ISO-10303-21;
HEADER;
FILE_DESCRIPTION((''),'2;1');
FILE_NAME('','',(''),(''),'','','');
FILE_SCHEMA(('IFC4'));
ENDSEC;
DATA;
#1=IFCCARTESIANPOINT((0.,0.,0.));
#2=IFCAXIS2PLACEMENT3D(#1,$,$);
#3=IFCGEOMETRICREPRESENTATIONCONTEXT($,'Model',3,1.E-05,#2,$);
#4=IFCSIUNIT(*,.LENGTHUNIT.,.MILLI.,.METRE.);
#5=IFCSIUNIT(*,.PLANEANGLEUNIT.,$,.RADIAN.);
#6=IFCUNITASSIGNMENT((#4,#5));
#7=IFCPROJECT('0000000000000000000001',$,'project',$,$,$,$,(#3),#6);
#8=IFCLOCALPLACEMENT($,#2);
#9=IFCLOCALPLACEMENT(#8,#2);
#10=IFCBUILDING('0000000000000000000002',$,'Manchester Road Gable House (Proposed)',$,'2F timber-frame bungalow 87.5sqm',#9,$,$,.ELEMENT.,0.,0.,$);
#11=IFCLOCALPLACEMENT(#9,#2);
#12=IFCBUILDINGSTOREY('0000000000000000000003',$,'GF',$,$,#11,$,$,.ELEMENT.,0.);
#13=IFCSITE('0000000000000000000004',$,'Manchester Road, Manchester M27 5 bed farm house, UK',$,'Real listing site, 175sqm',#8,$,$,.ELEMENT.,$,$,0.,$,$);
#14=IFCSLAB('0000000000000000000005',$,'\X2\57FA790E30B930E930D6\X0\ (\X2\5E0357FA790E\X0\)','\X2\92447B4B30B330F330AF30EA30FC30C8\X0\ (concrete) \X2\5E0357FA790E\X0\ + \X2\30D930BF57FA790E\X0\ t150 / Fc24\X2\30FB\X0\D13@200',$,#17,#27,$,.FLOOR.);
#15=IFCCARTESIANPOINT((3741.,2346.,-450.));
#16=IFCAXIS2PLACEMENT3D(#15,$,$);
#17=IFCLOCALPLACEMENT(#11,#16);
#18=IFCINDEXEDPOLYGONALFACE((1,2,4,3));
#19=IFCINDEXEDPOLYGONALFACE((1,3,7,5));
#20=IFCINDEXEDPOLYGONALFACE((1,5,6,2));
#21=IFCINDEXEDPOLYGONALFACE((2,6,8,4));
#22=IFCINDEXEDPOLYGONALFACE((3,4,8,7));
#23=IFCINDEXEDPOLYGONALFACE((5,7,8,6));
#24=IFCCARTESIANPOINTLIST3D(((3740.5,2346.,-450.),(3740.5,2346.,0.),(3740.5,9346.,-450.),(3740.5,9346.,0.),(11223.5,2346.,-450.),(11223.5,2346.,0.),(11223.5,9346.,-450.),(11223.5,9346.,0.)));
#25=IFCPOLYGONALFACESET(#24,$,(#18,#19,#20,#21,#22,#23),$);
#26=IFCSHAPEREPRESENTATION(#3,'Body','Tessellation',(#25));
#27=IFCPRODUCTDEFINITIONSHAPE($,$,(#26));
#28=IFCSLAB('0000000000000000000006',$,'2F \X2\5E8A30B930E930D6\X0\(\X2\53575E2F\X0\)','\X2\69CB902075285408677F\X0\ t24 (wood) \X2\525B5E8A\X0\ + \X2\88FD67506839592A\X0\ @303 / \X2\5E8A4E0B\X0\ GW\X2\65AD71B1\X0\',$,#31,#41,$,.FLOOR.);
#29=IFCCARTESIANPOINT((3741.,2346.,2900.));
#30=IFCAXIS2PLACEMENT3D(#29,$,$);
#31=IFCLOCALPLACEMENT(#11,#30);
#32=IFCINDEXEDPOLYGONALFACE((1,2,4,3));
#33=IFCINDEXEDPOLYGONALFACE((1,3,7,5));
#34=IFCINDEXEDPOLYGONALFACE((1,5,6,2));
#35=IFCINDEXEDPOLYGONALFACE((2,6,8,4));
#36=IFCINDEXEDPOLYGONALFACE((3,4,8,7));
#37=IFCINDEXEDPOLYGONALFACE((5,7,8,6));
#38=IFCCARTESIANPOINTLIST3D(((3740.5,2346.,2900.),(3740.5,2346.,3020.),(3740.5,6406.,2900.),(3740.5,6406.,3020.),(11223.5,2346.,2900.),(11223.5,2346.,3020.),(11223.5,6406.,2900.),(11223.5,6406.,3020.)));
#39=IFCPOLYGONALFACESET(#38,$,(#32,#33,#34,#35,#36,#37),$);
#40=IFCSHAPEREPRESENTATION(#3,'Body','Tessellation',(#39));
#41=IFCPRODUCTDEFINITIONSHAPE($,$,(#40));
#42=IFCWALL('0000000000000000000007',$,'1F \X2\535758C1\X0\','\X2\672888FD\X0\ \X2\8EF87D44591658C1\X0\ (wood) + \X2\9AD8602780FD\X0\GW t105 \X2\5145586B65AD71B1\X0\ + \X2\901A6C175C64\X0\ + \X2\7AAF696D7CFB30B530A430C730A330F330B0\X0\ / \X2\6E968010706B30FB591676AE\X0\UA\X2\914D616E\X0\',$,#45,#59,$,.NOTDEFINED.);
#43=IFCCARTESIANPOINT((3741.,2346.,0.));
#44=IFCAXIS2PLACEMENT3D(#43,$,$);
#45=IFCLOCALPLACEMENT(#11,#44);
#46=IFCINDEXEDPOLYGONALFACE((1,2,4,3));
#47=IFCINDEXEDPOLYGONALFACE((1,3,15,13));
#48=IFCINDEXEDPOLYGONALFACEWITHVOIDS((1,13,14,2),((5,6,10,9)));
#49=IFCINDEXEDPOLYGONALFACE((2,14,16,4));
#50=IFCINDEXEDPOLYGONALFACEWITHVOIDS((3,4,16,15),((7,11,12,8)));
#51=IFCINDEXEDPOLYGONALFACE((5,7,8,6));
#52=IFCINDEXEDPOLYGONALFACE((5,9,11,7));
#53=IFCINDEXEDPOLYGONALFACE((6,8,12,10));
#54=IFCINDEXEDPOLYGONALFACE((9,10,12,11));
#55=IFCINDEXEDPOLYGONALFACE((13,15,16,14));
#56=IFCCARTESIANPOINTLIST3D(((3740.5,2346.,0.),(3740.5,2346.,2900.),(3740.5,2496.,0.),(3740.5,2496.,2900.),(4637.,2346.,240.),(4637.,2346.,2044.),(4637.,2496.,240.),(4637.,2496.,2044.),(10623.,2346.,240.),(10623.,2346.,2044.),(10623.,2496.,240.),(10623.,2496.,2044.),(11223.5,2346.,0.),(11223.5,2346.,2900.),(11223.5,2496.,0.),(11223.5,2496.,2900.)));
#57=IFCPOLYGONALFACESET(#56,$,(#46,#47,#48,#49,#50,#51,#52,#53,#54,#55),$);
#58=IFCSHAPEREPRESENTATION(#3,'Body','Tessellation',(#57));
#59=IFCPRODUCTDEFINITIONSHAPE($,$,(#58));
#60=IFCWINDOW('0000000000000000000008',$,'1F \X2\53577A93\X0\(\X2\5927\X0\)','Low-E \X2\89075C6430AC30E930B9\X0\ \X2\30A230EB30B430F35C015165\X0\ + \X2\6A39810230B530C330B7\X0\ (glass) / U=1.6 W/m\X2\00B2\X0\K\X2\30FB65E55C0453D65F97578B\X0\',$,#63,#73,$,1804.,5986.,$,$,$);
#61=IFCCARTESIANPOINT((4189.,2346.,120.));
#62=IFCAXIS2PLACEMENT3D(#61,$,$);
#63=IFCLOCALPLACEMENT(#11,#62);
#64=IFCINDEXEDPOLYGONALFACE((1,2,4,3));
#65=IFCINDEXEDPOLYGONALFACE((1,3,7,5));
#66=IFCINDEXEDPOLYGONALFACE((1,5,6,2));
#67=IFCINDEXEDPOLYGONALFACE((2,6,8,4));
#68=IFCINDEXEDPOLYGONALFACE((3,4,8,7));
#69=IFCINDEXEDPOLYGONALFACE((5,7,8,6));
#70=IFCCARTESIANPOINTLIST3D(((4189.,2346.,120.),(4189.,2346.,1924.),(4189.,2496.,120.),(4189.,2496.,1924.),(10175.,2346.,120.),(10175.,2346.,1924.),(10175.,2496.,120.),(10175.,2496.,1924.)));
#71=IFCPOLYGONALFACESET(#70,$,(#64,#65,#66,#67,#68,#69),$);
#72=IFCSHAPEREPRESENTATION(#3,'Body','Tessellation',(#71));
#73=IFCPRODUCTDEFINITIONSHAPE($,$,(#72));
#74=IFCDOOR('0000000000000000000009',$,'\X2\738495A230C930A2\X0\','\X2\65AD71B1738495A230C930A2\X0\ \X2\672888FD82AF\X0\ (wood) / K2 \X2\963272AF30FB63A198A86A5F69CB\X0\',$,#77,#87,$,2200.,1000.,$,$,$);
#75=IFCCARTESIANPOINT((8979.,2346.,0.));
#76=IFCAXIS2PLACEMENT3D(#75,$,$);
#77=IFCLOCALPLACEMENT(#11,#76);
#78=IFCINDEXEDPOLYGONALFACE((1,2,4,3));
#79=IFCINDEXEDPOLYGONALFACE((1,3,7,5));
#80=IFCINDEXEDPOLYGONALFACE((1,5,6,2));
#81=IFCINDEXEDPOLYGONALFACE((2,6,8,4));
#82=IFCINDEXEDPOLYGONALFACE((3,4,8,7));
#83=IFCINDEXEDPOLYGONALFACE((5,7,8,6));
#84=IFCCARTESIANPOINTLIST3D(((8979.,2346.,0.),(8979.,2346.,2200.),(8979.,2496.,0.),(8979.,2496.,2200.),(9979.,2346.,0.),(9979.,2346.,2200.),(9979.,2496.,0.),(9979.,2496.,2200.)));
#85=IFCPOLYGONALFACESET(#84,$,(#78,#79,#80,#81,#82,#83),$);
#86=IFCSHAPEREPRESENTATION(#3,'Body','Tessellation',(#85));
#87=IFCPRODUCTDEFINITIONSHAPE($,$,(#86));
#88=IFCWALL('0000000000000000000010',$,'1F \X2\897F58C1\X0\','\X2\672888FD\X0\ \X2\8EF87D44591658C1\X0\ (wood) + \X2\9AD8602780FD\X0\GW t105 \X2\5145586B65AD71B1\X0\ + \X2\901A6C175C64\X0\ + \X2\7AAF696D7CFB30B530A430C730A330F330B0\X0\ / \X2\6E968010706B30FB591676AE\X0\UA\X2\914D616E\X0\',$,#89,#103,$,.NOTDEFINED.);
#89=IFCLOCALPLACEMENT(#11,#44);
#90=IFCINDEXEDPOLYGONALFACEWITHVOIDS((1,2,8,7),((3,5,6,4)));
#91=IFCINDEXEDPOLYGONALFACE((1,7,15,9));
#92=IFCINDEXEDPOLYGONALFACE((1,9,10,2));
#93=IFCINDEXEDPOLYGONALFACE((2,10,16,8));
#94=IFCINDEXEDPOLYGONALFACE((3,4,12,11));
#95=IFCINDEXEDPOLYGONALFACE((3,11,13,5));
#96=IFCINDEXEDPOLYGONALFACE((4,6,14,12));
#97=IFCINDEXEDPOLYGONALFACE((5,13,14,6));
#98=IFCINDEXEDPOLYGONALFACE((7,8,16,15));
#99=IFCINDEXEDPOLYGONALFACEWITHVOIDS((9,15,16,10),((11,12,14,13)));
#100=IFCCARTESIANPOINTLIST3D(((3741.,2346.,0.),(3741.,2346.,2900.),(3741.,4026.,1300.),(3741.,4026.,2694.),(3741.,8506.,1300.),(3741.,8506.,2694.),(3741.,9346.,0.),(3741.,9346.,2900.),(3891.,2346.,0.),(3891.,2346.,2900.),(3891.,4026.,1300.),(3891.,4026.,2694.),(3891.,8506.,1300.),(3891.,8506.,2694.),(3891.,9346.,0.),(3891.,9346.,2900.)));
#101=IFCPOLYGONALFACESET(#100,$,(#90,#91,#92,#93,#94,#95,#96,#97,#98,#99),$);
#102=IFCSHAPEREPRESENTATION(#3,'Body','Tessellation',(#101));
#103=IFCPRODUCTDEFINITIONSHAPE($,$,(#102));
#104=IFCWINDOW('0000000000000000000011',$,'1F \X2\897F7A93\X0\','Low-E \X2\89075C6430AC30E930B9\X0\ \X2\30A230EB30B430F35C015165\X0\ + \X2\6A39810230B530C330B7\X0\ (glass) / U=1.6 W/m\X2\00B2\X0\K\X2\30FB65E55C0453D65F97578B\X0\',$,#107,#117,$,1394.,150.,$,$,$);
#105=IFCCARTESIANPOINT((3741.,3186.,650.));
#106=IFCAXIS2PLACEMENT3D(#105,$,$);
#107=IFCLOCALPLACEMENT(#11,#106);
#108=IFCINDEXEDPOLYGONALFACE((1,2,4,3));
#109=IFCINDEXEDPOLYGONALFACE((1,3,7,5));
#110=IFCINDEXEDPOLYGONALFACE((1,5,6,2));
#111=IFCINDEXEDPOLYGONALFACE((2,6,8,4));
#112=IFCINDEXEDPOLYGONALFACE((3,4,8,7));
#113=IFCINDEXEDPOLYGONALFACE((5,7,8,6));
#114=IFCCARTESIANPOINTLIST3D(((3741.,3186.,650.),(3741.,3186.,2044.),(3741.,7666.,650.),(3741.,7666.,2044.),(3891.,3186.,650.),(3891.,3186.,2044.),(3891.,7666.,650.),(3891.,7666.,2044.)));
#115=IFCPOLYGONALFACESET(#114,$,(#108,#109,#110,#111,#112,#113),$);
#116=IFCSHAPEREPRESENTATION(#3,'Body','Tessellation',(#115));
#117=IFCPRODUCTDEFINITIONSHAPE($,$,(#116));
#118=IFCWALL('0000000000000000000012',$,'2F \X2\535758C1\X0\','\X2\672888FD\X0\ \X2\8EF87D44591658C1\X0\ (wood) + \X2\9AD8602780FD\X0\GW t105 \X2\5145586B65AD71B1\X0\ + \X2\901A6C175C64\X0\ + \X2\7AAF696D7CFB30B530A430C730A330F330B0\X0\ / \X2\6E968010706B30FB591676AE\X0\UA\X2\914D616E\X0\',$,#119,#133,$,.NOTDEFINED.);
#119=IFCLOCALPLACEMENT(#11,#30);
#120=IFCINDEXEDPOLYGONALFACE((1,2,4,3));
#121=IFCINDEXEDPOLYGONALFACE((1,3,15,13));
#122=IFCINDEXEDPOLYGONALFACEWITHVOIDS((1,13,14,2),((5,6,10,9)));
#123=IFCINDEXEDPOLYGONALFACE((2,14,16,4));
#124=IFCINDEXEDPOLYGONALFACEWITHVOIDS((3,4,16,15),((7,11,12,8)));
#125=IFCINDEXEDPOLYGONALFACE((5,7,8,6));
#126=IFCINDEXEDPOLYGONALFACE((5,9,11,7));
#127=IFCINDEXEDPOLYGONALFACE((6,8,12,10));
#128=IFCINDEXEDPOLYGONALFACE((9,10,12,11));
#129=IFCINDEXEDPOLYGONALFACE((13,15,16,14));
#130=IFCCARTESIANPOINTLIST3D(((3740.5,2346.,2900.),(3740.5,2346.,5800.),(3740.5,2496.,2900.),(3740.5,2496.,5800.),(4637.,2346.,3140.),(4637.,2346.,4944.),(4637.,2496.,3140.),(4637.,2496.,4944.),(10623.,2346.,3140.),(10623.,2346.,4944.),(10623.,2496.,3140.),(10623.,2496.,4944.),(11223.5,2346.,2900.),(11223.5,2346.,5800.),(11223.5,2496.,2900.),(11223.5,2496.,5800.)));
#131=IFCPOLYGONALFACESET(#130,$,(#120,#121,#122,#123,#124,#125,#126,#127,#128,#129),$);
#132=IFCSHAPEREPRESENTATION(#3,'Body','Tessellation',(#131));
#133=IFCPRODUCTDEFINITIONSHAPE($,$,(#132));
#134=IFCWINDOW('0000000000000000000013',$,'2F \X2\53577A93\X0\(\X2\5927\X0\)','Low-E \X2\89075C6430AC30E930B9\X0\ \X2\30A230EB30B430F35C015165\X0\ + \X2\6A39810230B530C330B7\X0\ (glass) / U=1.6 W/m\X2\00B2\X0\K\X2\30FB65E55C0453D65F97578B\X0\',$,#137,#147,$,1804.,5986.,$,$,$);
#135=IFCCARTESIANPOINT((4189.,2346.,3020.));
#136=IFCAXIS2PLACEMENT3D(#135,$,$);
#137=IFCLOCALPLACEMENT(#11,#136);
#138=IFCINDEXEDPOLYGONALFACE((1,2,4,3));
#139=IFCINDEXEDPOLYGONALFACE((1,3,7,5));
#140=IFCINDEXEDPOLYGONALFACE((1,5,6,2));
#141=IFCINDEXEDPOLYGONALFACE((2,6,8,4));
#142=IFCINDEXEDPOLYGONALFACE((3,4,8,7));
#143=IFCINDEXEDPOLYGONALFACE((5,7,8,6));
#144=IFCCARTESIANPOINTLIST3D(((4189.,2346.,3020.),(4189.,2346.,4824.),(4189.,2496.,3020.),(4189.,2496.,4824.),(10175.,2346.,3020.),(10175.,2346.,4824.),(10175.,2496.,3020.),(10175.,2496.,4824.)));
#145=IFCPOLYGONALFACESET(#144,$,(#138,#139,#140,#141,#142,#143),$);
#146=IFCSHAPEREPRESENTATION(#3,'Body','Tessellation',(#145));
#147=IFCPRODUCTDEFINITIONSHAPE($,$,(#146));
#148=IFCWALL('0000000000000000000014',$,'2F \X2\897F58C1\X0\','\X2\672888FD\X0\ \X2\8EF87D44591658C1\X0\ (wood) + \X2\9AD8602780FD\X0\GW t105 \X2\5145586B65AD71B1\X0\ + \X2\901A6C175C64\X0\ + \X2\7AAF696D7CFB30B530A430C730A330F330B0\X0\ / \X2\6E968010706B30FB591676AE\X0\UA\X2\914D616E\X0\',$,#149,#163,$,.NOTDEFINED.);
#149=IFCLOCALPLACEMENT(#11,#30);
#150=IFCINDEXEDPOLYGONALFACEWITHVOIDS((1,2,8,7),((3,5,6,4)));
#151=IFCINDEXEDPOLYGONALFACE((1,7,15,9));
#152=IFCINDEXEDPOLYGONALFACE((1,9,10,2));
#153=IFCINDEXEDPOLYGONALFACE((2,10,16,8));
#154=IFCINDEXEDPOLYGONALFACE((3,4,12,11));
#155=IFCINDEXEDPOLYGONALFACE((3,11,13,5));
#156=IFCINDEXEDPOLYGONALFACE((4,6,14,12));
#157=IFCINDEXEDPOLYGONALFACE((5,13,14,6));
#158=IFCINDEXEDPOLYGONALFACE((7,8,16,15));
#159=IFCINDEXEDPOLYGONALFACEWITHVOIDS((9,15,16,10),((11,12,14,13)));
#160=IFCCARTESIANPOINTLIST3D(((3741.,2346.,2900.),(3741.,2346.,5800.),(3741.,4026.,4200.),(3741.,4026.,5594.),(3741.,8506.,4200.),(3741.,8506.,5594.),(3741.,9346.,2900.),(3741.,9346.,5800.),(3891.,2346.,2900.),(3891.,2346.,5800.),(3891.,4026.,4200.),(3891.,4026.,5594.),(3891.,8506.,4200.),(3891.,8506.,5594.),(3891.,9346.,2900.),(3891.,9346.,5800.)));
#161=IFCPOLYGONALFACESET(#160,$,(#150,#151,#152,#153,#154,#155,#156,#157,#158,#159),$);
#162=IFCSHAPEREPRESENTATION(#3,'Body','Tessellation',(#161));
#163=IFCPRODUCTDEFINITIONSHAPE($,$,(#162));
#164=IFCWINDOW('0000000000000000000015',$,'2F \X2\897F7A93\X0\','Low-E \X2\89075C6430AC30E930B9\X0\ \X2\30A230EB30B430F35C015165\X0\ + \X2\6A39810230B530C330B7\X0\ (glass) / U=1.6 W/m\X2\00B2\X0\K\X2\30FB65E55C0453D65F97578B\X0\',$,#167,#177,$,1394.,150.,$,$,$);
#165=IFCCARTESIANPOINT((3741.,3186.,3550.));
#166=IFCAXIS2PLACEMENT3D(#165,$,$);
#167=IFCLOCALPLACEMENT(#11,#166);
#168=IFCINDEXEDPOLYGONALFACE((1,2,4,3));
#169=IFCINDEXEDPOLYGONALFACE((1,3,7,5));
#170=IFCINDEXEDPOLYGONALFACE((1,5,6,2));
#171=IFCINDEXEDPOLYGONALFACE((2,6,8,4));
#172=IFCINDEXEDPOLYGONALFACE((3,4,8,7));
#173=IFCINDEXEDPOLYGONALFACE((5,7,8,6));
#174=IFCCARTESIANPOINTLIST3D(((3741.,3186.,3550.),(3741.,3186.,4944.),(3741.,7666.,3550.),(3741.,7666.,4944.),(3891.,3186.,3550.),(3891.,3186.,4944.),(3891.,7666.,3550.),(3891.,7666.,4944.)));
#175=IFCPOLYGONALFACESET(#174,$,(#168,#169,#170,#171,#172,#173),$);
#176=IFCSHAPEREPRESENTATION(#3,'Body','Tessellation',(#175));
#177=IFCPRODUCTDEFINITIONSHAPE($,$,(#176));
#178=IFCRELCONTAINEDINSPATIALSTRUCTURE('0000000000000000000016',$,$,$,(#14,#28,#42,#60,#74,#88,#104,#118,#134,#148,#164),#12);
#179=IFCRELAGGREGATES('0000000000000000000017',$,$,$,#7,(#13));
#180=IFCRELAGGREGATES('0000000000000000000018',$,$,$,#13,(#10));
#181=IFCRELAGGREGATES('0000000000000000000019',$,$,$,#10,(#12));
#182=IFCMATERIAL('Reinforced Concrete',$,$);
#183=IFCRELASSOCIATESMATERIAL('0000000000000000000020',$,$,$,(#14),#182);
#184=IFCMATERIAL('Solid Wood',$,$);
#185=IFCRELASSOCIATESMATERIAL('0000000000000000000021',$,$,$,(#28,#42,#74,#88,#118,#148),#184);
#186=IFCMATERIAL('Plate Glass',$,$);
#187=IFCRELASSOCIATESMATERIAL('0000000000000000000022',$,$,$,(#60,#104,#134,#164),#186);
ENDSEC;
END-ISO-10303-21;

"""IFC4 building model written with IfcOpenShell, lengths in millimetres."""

from ifc_helpers import new_model, si_unit, frame, frame_2d, origin, place, context, project, spatial, rectangle, extrude, material, element, fill, save


model = new_model("IFC4")

# Units and contexts
model_context = context("Model", 3, precision=1e-05, world=origin())
ifc_project = project(units=[si_unit("LENGTHUNIT", "METRE", prefix="MILLI"), si_unit("PLANEANGLEUNIT", "RADIAN")], contexts=[model_context])

# Site, building, storey
site_placement = place(None, origin())
site = spatial("IfcSite", under=ifc_project, at=site_placement, Name="Manchester Road, Manchester M27 5 bed farm house, UK", ObjectType="Real listing site, 175sqm", CompositionType="ELEMENT", RefElevation=0.0)
building_placement = place(site_placement, origin())
building = spatial("IfcBuilding", under=site, at=building_placement, Name="Manchester Road Gable House (Proposed)", ObjectType="2F timber-frame bungalow 87.5sqm", CompositionType="ELEMENT", ElevationOfRefHeight=0.0, ElevationOfTerrain=0.0)
storey_placement = place(building_placement, origin())
storey = spatial("IfcBuildingStorey", under=building, at=storey_placement, Name="GF", CompositionType="ELEMENT", Elevation=0.0)

# Slabs
ifc_material_1 = material(Name="Reinforced Concrete")
slab_1_placement = place(storey_placement, frame((3741.0, 2346.0, -450.0)))
element("IfcSlab", 1, at=slab_1_placement, inside=storey, material=ifc_material_1, Name="基礎スラブ (布基礎)", Description="鉄筋コンクリート (concrete) 布基礎 + ベタ基礎 t150 / Fc24・D13@200", PredefinedType="FLOOR", context=model_context, shape_type="SweptSolid", body=[
    extrude(rectangle(XDim=7483.0, YDim=7000.0, at=frame_2d((3741.0, 3500.0))), frame((3741.0, 2346.0, -450.0)), (0.0, 0.0, 1.0), 450.0),
])
ifc_material_2 = material(Name="Solid Wood")
slab_2_placement = place(storey_placement, frame((3741.0, 2346.0, 2900.0)))
element("IfcSlab", 2, at=slab_2_placement, inside=storey, material=ifc_material_2, Name="2F 床スラブ(南帯)", Description="構造用合板 t24 (wood) 剛床 + 製材根太 @303 / 床下 GW断熱", PredefinedType="FLOOR", context=model_context, shape_type="SweptSolid", body=[
    extrude(rectangle(XDim=7483.0, YDim=4060.0, at=frame_2d((3741.0, 2030.0))), frame((3741.0, 2346.0, 2900.0)), (0.0, 0.0, 1.0), 120.0),
])

# Wall, openings, window, door
wall_1_placement = place(storey_placement, frame((3741.0, 2346.0, 0.0)))
wall_1 = element("IfcWall", 3, at=wall_1_placement, inside=storey, material=ifc_material_2, Name="1F 南壁", Description="木製 軸組外壁 (wood) + 高性能GW t105 充填断熱 + 通気層 + 窯業系サイディング / 準耐火・外皮UA配慮", PredefinedType="NOTDEFINED", context=model_context, shape_type="SweptSolid", body=[
    extrude(rectangle(XDim=7483.0, YDim=150.0, at=frame_2d((3741.0, 75.0))), frame((3741.0, 2346.0, 0.0)), (0.0, 0.0, 1.0), 2900.0),
])
opening_1_placement = place(storey_placement, frame((4189.0, 2346.0, 120.0)))
opening_1 = element("IfcOpeningElement", 4, at=opening_1_placement, cuts=wall_1, PredefinedType="NOTDEFINED", context=model_context, shape_type="SweptSolid", body=[
    extrude(rectangle(XDim=5986.0, YDim=150.0, at=frame_2d((2993.0, 75.0))), frame((4189.0, 2346.0, 120.0)), (0.0, 0.0, 1.0), 1804.0),
])
opening_2_placement = place(storey_placement, frame((8979.0, 2346.0, 0.0)))
opening_2 = element("IfcOpeningElement", 5, at=opening_2_placement, cuts=wall_1, PredefinedType="NOTDEFINED", context=model_context, shape_type="SweptSolid", body=[
    extrude(rectangle(XDim=1000.0, YDim=150.0, at=frame_2d((500.0, 75.0))), frame((8979.0, 2346.0, 0.0)), (0.0, 0.0, 1.0), 2200.0),
])
ifc_material_3 = material(Name="Plate Glass")
window_1_placement = place(storey_placement, frame((4189.0, 2346.0, 120.0)))
window_1 = element("IfcWindow", 6, at=window_1_placement, inside=storey, material=ifc_material_3, Name="1F 南窓(大)", Description="Low-E 複層ガラス アルゴン封入 + 樹脂サッシ (glass) / U=1.6 W/m²K・日射取得型", OverallHeight=1804.0, OverallWidth=5986.0, context=model_context, shape_type="SweptSolid", body=[
    extrude(rectangle(XDim=5986.0, YDim=150.0, at=frame_2d((2993.0, 75.0))), frame((4189.0, 2346.0, 120.0)), (0.0, 0.0, 1.0), 1804.0),
])
fill(opening_1, window_1)
door_placement = place(storey_placement, frame((8979.0, 2346.0, 0.0)))
door = element("IfcDoor", 7, at=door_placement, inside=storey, material=ifc_material_2, Name="玄関ドア", Description="断熱玄関ドア 木製芯 (wood) / K2 防犯・採風機構", OverallHeight=2200.0, OverallWidth=1000.0, context=model_context, shape_type="SweptSolid", body=[
    extrude(rectangle(XDim=1000.0, YDim=150.0, at=frame_2d((500.0, 75.0))), frame((8979.0, 2346.0, 0.0)), (0.0, 0.0, 1.0), 2200.0),
])
fill(opening_2, door)

# Wall, opening, window
wall_2_placement = place(storey_placement, frame((3741.0, 2346.0, 0.0)))
wall_2 = element("IfcWall", 8, at=wall_2_placement, inside=storey, material=ifc_material_2, Name="1F 西壁", Description="木製 軸組外壁 (wood) + 高性能GW t105 充填断熱 + 通気層 + 窯業系サイディング / 準耐火・外皮UA配慮", PredefinedType="NOTDEFINED", context=model_context, shape_type="SweptSolid", body=[
    extrude(rectangle(XDim=150.0, YDim=7000.0, at=frame_2d((75.0, 3500.0))), frame((3741.0, 2346.0, 0.0)), (0.0, 0.0, 1.0), 2900.0),
])
opening_3_placement = place(storey_placement, frame((3741.0, 3186.0, 650.0)))
opening_3 = element("IfcOpeningElement", 9, at=opening_3_placement, cuts=wall_2, PredefinedType="NOTDEFINED", context=model_context, shape_type="SweptSolid", body=[
    extrude(rectangle(XDim=150.0, YDim=4480.0, at=frame_2d((75.0, 2240.0))), frame((3741.0, 3186.0, 650.0)), (0.0, 0.0, 1.0), 1394.0),
])
window_2_placement = place(storey_placement, frame((3741.0, 3186.0, 650.0)))
window_2 = element("IfcWindow", 10, at=window_2_placement, inside=storey, material=ifc_material_3, Name="1F 西窓", Description="Low-E 複層ガラス アルゴン封入 + 樹脂サッシ (glass) / U=1.6 W/m²K・日射取得型", OverallHeight=1394.0, OverallWidth=150.0, context=model_context, shape_type="SweptSolid", body=[
    extrude(rectangle(XDim=150.0, YDim=4480.0, at=frame_2d((75.0, 2240.0))), frame((3741.0, 3186.0, 650.0)), (0.0, 0.0, 1.0), 1394.0),
])
fill(opening_3, window_2)

# Walls, openings, windows
wall_3_placement = place(storey_placement, frame((3741.0, 2346.0, 2900.0)))
wall_3 = element("IfcWall", 11, at=wall_3_placement, inside=storey, material=ifc_material_2, Name="2F 南壁", Description="木製 軸組外壁 (wood) + 高性能GW t105 充填断熱 + 通気層 + 窯業系サイディング / 準耐火・外皮UA配慮", PredefinedType="NOTDEFINED", context=model_context, shape_type="SweptSolid", body=[
    extrude(rectangle(XDim=7483.0, YDim=150.0, at=frame_2d((3741.0, 75.0))), frame((3741.0, 2346.0, 2900.0)), (0.0, 0.0, 1.0), 2900.0),
])
opening_4_placement = place(storey_placement, frame((4189.0, 2346.0, 3020.0)))
opening_4 = element("IfcOpeningElement", 12, at=opening_4_placement, cuts=wall_3, PredefinedType="NOTDEFINED", context=model_context, shape_type="SweptSolid", body=[
    extrude(rectangle(XDim=5986.0, YDim=150.0, at=frame_2d((2993.0, 75.0))), frame((4189.0, 2346.0, 3020.0)), (0.0, 0.0, 1.0), 1804.0),
])
window_3_placement = place(storey_placement, frame((4189.0, 2346.0, 3020.0)))
window_3 = element("IfcWindow", 13, at=window_3_placement, inside=storey, material=ifc_material_3, Name="2F 南窓(大)", Description="Low-E 複層ガラス アルゴン封入 + 樹脂サッシ (glass) / U=1.6 W/m²K・日射取得型", OverallHeight=1804.0, OverallWidth=5986.0, context=model_context, shape_type="SweptSolid", body=[
    extrude(rectangle(XDim=5986.0, YDim=150.0, at=frame_2d((2993.0, 75.0))), frame((4189.0, 2346.0, 3020.0)), (0.0, 0.0, 1.0), 1804.0),
])
fill(opening_4, window_3)
wall_4_placement = place(storey_placement, frame((3741.0, 2346.0, 2900.0)))
wall_4 = element("IfcWall", 14, at=wall_4_placement, inside=storey, material=ifc_material_2, Name="2F 西壁", Description="木製 軸組外壁 (wood) + 高性能GW t105 充填断熱 + 通気層 + 窯業系サイディング / 準耐火・外皮UA配慮", PredefinedType="NOTDEFINED", context=model_context, shape_type="SweptSolid", body=[
    extrude(rectangle(XDim=150.0, YDim=7000.0, at=frame_2d((75.0, 3500.0))), frame((3741.0, 2346.0, 2900.0)), (0.0, 0.0, 1.0), 2900.0),
])
opening_5_placement = place(storey_placement, frame((3741.0, 3186.0, 3550.0)))
opening_5 = element("IfcOpeningElement", 15, at=opening_5_placement, cuts=wall_4, PredefinedType="NOTDEFINED", context=model_context, shape_type="SweptSolid", body=[
    extrude(rectangle(XDim=150.0, YDim=4480.0, at=frame_2d((75.0, 2240.0))), frame((3741.0, 3186.0, 3550.0)), (0.0, 0.0, 1.0), 1394.0),
])
window_4_placement = place(storey_placement, frame((3741.0, 3186.0, 3550.0)))
window_4 = element("IfcWindow", 16, at=window_4_placement, inside=storey, material=ifc_material_3, Name="2F 西窓", Description="Low-E 複層ガラス アルゴン封入 + 樹脂サッシ (glass) / U=1.6 W/m²K・日射取得型", OverallHeight=1394.0, OverallWidth=150.0, context=model_context, shape_type="SweptSolid", body=[
    extrude(rectangle(XDim=150.0, YDim=4480.0, at=frame_2d((75.0, 2240.0))), frame((3741.0, 3186.0, 3550.0)), (0.0, 0.0, 1.0), 1394.0),
])
fill(opening_5, window_4)

save(model, "model.ifc")
